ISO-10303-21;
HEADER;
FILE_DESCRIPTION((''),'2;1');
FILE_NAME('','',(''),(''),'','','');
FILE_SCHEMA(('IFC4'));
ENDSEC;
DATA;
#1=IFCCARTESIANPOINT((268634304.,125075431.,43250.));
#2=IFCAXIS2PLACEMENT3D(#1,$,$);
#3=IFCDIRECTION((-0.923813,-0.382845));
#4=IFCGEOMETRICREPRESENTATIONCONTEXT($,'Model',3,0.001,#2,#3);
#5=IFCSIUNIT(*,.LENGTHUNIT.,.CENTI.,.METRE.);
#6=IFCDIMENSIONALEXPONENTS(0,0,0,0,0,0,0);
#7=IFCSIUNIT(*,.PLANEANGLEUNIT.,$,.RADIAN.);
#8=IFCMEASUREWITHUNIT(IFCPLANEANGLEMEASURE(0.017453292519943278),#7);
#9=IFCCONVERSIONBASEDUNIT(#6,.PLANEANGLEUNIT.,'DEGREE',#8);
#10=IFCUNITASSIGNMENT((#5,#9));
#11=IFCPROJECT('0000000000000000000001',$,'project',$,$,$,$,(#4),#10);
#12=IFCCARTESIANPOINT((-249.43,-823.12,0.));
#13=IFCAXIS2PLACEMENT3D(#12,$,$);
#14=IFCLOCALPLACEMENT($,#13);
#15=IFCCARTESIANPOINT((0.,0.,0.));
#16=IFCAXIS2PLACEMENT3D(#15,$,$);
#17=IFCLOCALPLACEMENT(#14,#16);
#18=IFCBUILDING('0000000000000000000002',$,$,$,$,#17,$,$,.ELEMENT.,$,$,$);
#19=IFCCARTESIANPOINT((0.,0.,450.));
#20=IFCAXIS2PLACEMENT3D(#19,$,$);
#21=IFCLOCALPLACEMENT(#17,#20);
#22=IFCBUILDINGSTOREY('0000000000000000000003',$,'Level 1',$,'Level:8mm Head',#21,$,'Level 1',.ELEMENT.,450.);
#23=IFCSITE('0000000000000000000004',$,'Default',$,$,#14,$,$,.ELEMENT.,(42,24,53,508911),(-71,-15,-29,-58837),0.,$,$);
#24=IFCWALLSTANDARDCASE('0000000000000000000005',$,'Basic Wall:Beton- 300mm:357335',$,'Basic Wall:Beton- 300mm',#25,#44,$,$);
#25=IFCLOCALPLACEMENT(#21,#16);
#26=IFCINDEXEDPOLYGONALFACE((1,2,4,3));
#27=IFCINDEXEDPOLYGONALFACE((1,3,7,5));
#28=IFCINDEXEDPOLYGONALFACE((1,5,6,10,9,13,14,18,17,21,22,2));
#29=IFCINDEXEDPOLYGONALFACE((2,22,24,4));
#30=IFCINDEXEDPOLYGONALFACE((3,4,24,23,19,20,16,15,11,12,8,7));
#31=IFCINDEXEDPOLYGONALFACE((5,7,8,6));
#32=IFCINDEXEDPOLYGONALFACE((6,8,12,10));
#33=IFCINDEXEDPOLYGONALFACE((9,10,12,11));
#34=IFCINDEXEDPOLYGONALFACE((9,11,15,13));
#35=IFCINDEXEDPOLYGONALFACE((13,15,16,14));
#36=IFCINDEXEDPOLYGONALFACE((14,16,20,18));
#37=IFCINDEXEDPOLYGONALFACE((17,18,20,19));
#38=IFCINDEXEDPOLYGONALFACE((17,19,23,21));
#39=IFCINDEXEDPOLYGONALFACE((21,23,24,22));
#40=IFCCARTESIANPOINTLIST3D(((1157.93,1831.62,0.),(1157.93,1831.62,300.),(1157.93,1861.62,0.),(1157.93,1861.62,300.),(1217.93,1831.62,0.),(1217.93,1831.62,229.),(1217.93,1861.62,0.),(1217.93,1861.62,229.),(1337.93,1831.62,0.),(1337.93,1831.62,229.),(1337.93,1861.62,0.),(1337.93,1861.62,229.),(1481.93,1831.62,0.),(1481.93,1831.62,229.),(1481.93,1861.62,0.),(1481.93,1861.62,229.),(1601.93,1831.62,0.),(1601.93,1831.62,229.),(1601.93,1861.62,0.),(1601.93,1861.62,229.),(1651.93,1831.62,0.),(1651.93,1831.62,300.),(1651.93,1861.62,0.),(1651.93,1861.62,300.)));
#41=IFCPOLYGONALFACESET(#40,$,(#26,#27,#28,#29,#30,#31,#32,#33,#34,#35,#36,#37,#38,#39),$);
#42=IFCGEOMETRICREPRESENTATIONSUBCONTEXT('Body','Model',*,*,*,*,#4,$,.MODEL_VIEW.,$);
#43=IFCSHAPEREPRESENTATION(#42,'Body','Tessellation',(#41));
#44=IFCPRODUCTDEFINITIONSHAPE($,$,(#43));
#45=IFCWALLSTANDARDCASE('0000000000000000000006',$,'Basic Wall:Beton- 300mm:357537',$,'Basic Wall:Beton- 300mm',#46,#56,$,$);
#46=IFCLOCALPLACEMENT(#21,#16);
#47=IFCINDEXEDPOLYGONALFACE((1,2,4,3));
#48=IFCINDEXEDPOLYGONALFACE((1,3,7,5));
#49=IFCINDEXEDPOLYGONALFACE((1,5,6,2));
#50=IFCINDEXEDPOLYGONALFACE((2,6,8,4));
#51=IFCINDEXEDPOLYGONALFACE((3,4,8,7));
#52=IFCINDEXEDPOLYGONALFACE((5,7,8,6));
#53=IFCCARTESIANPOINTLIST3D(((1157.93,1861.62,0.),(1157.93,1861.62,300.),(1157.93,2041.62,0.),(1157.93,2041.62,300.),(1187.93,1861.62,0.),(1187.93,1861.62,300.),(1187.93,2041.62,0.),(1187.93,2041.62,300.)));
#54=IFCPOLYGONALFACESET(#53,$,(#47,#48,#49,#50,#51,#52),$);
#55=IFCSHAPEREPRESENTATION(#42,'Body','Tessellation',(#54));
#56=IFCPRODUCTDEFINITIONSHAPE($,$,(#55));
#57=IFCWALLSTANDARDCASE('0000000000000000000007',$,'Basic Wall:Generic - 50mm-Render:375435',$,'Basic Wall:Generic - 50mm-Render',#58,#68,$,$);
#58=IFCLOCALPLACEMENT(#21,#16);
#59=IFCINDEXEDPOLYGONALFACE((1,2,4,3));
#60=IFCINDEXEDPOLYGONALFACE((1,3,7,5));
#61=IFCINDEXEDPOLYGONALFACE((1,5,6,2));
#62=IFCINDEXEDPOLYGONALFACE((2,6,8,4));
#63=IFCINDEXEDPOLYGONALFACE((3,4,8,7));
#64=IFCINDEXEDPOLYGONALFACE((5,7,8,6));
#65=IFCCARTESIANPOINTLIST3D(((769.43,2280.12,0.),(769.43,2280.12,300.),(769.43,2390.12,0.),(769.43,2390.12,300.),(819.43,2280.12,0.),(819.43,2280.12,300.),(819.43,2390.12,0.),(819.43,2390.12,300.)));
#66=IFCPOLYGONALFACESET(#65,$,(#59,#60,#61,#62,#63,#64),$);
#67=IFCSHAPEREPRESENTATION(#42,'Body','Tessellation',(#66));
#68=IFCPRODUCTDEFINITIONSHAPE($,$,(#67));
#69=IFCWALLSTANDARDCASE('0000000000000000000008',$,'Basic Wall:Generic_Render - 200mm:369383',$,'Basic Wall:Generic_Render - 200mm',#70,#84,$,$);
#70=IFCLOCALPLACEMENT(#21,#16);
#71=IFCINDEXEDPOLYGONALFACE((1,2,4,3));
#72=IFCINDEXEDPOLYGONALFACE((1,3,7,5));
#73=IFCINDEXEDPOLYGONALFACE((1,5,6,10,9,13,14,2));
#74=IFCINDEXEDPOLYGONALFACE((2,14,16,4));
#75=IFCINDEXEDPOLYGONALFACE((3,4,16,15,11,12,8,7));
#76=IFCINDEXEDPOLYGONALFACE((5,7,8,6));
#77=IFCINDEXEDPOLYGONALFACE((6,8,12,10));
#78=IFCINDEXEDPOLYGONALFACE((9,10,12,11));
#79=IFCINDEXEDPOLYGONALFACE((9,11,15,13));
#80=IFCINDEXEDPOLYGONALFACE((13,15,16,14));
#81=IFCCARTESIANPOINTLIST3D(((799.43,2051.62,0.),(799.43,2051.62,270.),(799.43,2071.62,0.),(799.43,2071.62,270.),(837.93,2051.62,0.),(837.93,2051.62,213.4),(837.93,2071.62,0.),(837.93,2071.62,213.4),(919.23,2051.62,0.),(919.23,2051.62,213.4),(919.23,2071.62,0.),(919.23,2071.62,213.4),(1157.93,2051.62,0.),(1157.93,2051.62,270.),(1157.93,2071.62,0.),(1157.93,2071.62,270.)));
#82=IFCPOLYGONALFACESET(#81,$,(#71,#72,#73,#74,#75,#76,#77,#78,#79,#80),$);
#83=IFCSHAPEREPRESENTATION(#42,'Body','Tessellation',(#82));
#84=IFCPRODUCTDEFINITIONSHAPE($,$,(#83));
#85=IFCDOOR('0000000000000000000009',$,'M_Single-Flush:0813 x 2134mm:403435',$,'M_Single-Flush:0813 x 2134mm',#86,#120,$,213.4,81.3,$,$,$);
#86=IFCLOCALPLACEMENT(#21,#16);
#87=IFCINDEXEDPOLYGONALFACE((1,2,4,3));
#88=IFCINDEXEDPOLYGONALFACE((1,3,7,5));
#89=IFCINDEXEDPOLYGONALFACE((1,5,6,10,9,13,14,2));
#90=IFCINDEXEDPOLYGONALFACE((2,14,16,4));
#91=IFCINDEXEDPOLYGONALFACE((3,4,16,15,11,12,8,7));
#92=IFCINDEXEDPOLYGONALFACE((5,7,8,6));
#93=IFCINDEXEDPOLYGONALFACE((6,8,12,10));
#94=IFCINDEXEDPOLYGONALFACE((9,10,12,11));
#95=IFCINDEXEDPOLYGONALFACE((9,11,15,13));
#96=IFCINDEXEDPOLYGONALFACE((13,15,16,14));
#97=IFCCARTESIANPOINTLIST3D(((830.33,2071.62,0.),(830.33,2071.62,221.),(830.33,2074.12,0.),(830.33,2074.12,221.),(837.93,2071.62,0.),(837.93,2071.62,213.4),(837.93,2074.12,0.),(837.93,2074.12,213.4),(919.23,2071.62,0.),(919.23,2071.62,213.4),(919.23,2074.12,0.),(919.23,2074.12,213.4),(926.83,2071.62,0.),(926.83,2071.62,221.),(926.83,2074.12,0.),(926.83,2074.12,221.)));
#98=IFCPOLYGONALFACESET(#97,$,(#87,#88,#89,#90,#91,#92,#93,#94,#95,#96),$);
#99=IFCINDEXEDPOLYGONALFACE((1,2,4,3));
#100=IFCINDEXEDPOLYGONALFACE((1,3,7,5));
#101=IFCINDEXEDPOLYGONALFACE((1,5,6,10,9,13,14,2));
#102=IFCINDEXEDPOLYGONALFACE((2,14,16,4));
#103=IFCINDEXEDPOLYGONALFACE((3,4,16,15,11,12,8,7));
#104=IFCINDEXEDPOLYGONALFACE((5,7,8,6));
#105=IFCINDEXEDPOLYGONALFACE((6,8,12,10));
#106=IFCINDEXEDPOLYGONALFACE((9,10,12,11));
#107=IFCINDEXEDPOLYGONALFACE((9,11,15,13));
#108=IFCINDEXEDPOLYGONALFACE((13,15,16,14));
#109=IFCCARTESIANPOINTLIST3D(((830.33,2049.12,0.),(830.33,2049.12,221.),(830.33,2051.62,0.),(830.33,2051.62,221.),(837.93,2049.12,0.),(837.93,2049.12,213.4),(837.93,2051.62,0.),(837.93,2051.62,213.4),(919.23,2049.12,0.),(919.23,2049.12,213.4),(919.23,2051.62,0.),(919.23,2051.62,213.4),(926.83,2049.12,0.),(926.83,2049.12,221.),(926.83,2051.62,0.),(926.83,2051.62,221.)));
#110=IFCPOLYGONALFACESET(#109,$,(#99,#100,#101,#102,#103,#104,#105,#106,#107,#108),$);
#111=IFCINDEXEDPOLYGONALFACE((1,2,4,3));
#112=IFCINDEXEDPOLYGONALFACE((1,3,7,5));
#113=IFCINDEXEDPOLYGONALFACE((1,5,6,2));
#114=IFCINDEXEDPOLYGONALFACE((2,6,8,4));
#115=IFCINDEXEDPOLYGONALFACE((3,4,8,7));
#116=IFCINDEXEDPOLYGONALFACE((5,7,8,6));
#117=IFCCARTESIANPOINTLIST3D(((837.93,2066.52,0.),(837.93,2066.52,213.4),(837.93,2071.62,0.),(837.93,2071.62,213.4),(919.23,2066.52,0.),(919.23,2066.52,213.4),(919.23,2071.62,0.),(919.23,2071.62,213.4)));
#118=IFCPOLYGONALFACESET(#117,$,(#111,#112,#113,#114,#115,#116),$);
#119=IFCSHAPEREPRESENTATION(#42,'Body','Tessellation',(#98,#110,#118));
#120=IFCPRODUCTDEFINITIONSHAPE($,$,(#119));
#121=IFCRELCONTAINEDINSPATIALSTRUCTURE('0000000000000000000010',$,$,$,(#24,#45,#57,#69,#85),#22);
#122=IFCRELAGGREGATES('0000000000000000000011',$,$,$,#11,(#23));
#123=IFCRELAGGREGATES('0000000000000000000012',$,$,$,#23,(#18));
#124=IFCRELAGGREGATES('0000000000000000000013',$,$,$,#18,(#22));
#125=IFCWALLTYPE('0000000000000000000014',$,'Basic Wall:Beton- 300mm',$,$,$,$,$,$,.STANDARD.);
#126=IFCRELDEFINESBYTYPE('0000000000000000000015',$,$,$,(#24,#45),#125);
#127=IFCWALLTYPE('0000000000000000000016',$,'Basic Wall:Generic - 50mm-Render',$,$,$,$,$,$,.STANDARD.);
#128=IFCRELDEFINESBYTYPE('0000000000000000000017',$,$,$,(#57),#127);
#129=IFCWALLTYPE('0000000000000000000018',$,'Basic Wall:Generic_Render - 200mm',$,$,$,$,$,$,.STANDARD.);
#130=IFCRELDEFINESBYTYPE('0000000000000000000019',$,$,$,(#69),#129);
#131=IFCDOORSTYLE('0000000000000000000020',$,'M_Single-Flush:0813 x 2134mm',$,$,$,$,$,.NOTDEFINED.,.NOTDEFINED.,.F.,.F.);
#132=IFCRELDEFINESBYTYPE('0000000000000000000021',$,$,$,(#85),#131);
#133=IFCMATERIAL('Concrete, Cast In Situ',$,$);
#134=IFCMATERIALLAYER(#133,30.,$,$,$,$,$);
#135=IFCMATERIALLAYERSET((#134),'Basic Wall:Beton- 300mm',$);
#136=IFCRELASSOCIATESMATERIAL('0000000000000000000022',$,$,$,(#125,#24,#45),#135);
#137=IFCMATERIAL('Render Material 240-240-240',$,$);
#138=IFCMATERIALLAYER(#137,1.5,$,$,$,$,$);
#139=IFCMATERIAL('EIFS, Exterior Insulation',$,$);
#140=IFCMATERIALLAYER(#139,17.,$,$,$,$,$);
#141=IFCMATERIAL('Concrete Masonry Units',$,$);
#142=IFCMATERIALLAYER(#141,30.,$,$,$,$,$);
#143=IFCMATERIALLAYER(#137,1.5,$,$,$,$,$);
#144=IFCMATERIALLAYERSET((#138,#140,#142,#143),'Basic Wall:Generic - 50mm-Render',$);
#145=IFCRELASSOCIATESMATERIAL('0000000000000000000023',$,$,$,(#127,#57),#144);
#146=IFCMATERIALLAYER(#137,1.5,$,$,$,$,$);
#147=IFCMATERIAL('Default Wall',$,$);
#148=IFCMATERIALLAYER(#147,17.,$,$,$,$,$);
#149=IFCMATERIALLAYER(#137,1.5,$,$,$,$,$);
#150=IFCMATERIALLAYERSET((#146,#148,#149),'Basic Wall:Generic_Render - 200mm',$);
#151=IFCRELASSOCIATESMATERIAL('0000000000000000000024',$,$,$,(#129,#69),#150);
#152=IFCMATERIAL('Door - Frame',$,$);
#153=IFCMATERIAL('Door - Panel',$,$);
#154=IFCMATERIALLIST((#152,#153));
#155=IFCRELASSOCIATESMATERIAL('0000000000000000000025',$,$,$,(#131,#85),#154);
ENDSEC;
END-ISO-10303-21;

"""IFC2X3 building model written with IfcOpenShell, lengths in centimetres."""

from ifc_helpers import new_model, entity, si_unit, converted_unit, direction, frame, frame_2d, origin, place, context, subcontext, project, spatial, polyline, rectangle, outline, extrude, source, transform, mapped, material, material_list, layer, layer_set, layer_usage, type_object, type_shapes, element, fill, save


model = new_model("IFC2X3")

# Units and contexts
model_context = context("Model", 3, precision=0.001, world=frame((268634304.0, 125075431.0, 43250.0)), true_north=direction((-0.923813, -0.382845)))
body_context = subcontext(model_context, "Body", "Model", "MODEL_VIEW")
ifc_project = project(units=[si_unit("LENGTHUNIT", "METRE", prefix="CENTI"), converted_unit("PLANEANGLEUNIT", "DEGREE", entity("IfcPlaneAngleMeasure", 0.017453292519943278), si_unit("PLANEANGLEUNIT", "RADIAN"), dimensions=[0, 0, 0, 0, 0, 0, 0])], contexts=[model_context])

# Site, building, storey
site_placement = place(None, frame((-249.43, -823.12, 0.0)))
site = spatial("IfcSite", under=ifc_project, at=site_placement, Name="Default", CompositionType="ELEMENT", RefLatitude=(42, 24, 53, 508911), RefLongitude=(-71, -15, -29, -58837), RefElevation=0.0)
building_placement = place(site_placement, origin())
building = spatial("IfcBuilding", under=site, at=building_placement, CompositionType="ELEMENT")
storey_placement = place(building_placement, frame((0.0, 0.0, 450.0)))
storey = spatial("IfcBuildingStorey", under=building, at=storey_placement, Name="Level 1", ObjectType="Level:8mm Head", LongName="Level 1", CompositionType="ELEMENT", Elevation=450.0)

# Wall, openings
ifc_material_1 = material(Name="Concrete, Cast In Situ")
ifc_layer_1 = layer(ifc_material_1, 30.0)
ifc_layer_set_1 = layer_set([ifc_layer_1], Name="Basic Wall:Beton- 300mm")
ifc_layer_usage_1 = layer_usage(ifc_layer_set_1, "AXIS2", "NEGATIVE", 15.0)
wall_type_1 = type_object("IfcWallType", Name="Basic Wall:Beton- 300mm", PredefinedType="STANDARD", material=ifc_layer_set_1)
wall_1_placement = place(storey_placement, frame((1157.93, 1846.62, 0.0)))
wall_1 = element("IfcWallStandardCase", 1, at=wall_1_placement, inside=storey, type_object=wall_type_1, material=ifc_layer_usage_1, Name="Basic Wall:Beton- 300mm:357335", ObjectType="Basic Wall:Beton- 300mm", context=body_context, shape_type="SweptSolid", body=[
    extrude(rectangle(XDim=494.0, YDim=30.0, at=frame_2d((247.0, 0.0), x_axis=(-1.0, 0.0))), origin(), (0.0, 0.0, 1.0), 300.0),
])
opening_1_placement = place(wall_1_placement, frame((60.0, -15.0, 0.0)))
element("IfcOpeningElement", 2, at=opening_1_placement, cuts=wall_1, ObjectType="Opening", context=body_context, shape_type="SweptSolid", body=[
    extrude(rectangle(XDim=120.0, YDim=229.0, at=frame_2d((114.5, 60.0), x_axis=(0.0, 1.0))), frame((0.0, 0.0, 0.0), z_axis=(0.0, 1.0, 0.0), x_axis=(0.0, 0.0, 1.0)), (0.0, 0.0, 1.0), 30.0),
])
opening_2_placement = place(wall_1_placement, frame((324.0, -15.0, 0.0)))
element("IfcOpeningElement", 3, at=opening_2_placement, cuts=wall_1, ObjectType="Opening", context=body_context, shape_type="SweptSolid", body=[
    extrude(rectangle(XDim=120.0, YDim=229.0, at=frame_2d((114.5, 60.0), x_axis=(0.0, 1.0))), frame((0.0, 0.0, 0.0), z_axis=(0.0, 1.0, 0.0), x_axis=(0.0, 0.0, 1.0)), (0.0, 0.0, 1.0), 30.0),
])

# Wall
ifc_layer_usage_2 = layer_usage(ifc_layer_set_1, "AXIS2", "POSITIVE", -15.0)
wall_2_placement = place(storey_placement, frame((1172.93, 2041.62, 0.0), z_axis=(0.0, 0.0, 1.0), x_axis=(0.0, -1.0, 0.0)))
element("IfcWallStandardCase", 4, at=wall_2_placement, inside=storey, type_object=wall_type_1, material=ifc_layer_usage_2, Name="Basic Wall:Beton- 300mm:357537", ObjectType="Basic Wall:Beton- 300mm", context=body_context, shape_type="SweptSolid", body=[
    extrude(rectangle(XDim=180.0, YDim=30.0, at=frame_2d((90.0, 0.0), x_axis=(-1.0, 0.0))), origin(), (0.0, 0.0, 1.0), 300.0),
])

# Wall
ifc_material_2 = material(Name="Render Material 240-240-240")
ifc_layer_2 = layer(ifc_material_2, 1.5)
ifc_material_3 = material(Name="EIFS, Exterior Insulation")
ifc_layer_3 = layer(ifc_material_3, 17.0)
ifc_material_4 = material(Name="Concrete Masonry Units")
ifc_layer_4 = layer(ifc_material_4, 30.0)
ifc_layer_5 = layer(ifc_material_2, 1.5)
ifc_layer_set_2 = layer_set([ifc_layer_2, ifc_layer_3, ifc_layer_4, ifc_layer_5], Name="Basic Wall:Generic - 50mm-Render")
ifc_layer_usage_3 = layer_usage(ifc_layer_set_2, "AXIS2", "NEGATIVE", 25.0)
wall_type_2 = type_object("IfcWallType", Name="Basic Wall:Generic - 50mm-Render", PredefinedType="STANDARD", material=ifc_layer_set_2)
wall_3_placement = place(storey_placement, frame((794.43, 2280.12, 0.0), z_axis=(0.0, 0.0, 1.0), x_axis=(0.0, 1.0, 0.0)))
element("IfcWallStandardCase", 5, at=wall_3_placement, inside=storey, type_object=wall_type_2, material=ifc_layer_usage_3, Name="Basic Wall:Generic - 50mm-Render:375435", ObjectType="Basic Wall:Generic - 50mm-Render", context=body_context, shape_type="SweptSolid", body=[
    extrude(rectangle(XDim=110.0, YDim=50.0, at=frame_2d((55.0, 0.0), x_axis=(-1.0, 0.0))), origin(), (0.0, 0.0, 1.0), 300.0),
])

# Wall, opening, door
ifc_layer_6 = layer(ifc_material_2, 1.5)
ifc_material_5 = material(Name="Default Wall")
ifc_layer_7 = layer(ifc_material_5, 17.0)
ifc_layer_8 = layer(ifc_material_2, 1.5)
ifc_layer_set_3 = layer_set([ifc_layer_6, ifc_layer_7, ifc_layer_8], Name="Basic Wall:Generic_Render - 200mm")
ifc_layer_usage_4 = layer_usage(ifc_layer_set_3, "AXIS2", "NEGATIVE", 10.0)
wall_type_3 = type_object("IfcWallType", Name="Basic Wall:Generic_Render - 200mm", PredefinedType="STANDARD", material=ifc_layer_set_3)
wall_4_placement = place(storey_placement, frame((1157.93, 2061.62, 0.0), z_axis=(0.0, 0.0, 1.0), x_axis=(-1.0, 0.0, 0.0)))
wall_4 = element("IfcWallStandardCase", 6, at=wall_4_placement, inside=storey, type_object=wall_type_3, material=ifc_layer_usage_4, Name="Basic Wall:Generic_Render - 200mm:369383", ObjectType="Basic Wall:Generic_Render - 200mm", context=body_context, shape_type="SweptSolid", body=[
    extrude(rectangle(XDim=358.5, YDim=20.0, at=frame_2d((179.25, 0.0), x_axis=(-1.0, 0.0))), origin(), (0.0, 0.0, 1.0), 270.0),
])
opening_3_placement = place(wall_4_placement, frame((320.0, 10.0, 0.0)))
opening_3 = element("IfcOpeningElement", 7, at=opening_3_placement, cuts=wall_4, ObjectType="Opening", context=body_context, shape_type="SweptSolid", body=[
    extrude(rectangle(XDim=81.3, YDim=213.4, at=frame_2d((106.7, 40.65), x_axis=(0.0, -1.0))), frame((0.0, 0.0, 0.0), z_axis=(0.0, -1.0, 0.0), x_axis=(0.0, 0.0, 1.0)), (0.0, 0.0, 1.0), 20.0),
])
ifc_material_6 = material(Name="Door - Frame")
ifc_material_7 = material(Name="Door - Panel")
ifc_material_list_1 = material_list([ifc_material_6, ifc_material_7])
door_style_1 = type_object("IfcDoorStyle", Name="M_Single-Flush:0813 x 2134mm", ConstructionType="NOTDEFINED", OperationType="NOTDEFINED", ParameterTakesPrecedence=False, Sizeable=False, material=ifc_material_list_1)
shared_shape_1 = source(origin(), body_context, "Body", "SweptSolid", [
    extrude(outline(polyline([(-48.25, -112.4), (48.25, -112.4), (48.25, 108.6), (40.65, 108.6), (40.65, -104.8), (-40.65, -104.8), (-40.65, 108.6), (-48.25, 108.6), (-48.25, -112.4)])), frame((40.65, 22.5, 108.6), z_axis=(0.0, -1.0, 0.0), x_axis=(-1.0, 0.0, 0.0)), (0.0, 0.0, 1.0), 2.5),
    extrude(outline(polyline([(-112.4, -48.25), (108.6, -48.25), (108.6, -40.65), (-104.8, -40.65), (-104.8, 40.65), (108.6, 40.65), (108.6, 48.25), (-112.4, 48.25), (-112.4, -48.25)])), frame((40.65, 0.0, 108.6), z_axis=(0.0, -1.0, 0.0), x_axis=(0.0, 0.0, -1.0)), (0.0, 0.0, 1.0), 2.5),
    extrude(rectangle(XDim=81.3, YDim=5.1, at=frame_2d((0.0, 0.0), x_axis=(1.0, 0.0))), frame((40.65, 17.45, 0.0)), (0.0, 0.0, 1.0), 213.4),
])
type_shapes(door_style_1, [shared_shape_1])
door_1_placement = place(opening_3_placement, frame((0.0, 0.0, 0.0), z_axis=(0.0, 0.0, 1.0), x_axis=(-1.0, 0.0, 0.0)))
door_1 = element("IfcDoor", 8, at=door_1_placement, inside=storey, type_object=door_style_1, material=ifc_material_list_1, Name="M_Single-Flush:0813 x 2134mm:403435", ObjectType="M_Single-Flush:0813 x 2134mm", OverallHeight=213.4, OverallWidth=81.3, context=body_context, shape_type="MappedRepresentation", body=[
    mapped(shared_shape_1, transform((0.0, 0.0, 0.0), scale=1.0)),
])
fill(opening_3, door_1)

save(model, "model.ifc")
